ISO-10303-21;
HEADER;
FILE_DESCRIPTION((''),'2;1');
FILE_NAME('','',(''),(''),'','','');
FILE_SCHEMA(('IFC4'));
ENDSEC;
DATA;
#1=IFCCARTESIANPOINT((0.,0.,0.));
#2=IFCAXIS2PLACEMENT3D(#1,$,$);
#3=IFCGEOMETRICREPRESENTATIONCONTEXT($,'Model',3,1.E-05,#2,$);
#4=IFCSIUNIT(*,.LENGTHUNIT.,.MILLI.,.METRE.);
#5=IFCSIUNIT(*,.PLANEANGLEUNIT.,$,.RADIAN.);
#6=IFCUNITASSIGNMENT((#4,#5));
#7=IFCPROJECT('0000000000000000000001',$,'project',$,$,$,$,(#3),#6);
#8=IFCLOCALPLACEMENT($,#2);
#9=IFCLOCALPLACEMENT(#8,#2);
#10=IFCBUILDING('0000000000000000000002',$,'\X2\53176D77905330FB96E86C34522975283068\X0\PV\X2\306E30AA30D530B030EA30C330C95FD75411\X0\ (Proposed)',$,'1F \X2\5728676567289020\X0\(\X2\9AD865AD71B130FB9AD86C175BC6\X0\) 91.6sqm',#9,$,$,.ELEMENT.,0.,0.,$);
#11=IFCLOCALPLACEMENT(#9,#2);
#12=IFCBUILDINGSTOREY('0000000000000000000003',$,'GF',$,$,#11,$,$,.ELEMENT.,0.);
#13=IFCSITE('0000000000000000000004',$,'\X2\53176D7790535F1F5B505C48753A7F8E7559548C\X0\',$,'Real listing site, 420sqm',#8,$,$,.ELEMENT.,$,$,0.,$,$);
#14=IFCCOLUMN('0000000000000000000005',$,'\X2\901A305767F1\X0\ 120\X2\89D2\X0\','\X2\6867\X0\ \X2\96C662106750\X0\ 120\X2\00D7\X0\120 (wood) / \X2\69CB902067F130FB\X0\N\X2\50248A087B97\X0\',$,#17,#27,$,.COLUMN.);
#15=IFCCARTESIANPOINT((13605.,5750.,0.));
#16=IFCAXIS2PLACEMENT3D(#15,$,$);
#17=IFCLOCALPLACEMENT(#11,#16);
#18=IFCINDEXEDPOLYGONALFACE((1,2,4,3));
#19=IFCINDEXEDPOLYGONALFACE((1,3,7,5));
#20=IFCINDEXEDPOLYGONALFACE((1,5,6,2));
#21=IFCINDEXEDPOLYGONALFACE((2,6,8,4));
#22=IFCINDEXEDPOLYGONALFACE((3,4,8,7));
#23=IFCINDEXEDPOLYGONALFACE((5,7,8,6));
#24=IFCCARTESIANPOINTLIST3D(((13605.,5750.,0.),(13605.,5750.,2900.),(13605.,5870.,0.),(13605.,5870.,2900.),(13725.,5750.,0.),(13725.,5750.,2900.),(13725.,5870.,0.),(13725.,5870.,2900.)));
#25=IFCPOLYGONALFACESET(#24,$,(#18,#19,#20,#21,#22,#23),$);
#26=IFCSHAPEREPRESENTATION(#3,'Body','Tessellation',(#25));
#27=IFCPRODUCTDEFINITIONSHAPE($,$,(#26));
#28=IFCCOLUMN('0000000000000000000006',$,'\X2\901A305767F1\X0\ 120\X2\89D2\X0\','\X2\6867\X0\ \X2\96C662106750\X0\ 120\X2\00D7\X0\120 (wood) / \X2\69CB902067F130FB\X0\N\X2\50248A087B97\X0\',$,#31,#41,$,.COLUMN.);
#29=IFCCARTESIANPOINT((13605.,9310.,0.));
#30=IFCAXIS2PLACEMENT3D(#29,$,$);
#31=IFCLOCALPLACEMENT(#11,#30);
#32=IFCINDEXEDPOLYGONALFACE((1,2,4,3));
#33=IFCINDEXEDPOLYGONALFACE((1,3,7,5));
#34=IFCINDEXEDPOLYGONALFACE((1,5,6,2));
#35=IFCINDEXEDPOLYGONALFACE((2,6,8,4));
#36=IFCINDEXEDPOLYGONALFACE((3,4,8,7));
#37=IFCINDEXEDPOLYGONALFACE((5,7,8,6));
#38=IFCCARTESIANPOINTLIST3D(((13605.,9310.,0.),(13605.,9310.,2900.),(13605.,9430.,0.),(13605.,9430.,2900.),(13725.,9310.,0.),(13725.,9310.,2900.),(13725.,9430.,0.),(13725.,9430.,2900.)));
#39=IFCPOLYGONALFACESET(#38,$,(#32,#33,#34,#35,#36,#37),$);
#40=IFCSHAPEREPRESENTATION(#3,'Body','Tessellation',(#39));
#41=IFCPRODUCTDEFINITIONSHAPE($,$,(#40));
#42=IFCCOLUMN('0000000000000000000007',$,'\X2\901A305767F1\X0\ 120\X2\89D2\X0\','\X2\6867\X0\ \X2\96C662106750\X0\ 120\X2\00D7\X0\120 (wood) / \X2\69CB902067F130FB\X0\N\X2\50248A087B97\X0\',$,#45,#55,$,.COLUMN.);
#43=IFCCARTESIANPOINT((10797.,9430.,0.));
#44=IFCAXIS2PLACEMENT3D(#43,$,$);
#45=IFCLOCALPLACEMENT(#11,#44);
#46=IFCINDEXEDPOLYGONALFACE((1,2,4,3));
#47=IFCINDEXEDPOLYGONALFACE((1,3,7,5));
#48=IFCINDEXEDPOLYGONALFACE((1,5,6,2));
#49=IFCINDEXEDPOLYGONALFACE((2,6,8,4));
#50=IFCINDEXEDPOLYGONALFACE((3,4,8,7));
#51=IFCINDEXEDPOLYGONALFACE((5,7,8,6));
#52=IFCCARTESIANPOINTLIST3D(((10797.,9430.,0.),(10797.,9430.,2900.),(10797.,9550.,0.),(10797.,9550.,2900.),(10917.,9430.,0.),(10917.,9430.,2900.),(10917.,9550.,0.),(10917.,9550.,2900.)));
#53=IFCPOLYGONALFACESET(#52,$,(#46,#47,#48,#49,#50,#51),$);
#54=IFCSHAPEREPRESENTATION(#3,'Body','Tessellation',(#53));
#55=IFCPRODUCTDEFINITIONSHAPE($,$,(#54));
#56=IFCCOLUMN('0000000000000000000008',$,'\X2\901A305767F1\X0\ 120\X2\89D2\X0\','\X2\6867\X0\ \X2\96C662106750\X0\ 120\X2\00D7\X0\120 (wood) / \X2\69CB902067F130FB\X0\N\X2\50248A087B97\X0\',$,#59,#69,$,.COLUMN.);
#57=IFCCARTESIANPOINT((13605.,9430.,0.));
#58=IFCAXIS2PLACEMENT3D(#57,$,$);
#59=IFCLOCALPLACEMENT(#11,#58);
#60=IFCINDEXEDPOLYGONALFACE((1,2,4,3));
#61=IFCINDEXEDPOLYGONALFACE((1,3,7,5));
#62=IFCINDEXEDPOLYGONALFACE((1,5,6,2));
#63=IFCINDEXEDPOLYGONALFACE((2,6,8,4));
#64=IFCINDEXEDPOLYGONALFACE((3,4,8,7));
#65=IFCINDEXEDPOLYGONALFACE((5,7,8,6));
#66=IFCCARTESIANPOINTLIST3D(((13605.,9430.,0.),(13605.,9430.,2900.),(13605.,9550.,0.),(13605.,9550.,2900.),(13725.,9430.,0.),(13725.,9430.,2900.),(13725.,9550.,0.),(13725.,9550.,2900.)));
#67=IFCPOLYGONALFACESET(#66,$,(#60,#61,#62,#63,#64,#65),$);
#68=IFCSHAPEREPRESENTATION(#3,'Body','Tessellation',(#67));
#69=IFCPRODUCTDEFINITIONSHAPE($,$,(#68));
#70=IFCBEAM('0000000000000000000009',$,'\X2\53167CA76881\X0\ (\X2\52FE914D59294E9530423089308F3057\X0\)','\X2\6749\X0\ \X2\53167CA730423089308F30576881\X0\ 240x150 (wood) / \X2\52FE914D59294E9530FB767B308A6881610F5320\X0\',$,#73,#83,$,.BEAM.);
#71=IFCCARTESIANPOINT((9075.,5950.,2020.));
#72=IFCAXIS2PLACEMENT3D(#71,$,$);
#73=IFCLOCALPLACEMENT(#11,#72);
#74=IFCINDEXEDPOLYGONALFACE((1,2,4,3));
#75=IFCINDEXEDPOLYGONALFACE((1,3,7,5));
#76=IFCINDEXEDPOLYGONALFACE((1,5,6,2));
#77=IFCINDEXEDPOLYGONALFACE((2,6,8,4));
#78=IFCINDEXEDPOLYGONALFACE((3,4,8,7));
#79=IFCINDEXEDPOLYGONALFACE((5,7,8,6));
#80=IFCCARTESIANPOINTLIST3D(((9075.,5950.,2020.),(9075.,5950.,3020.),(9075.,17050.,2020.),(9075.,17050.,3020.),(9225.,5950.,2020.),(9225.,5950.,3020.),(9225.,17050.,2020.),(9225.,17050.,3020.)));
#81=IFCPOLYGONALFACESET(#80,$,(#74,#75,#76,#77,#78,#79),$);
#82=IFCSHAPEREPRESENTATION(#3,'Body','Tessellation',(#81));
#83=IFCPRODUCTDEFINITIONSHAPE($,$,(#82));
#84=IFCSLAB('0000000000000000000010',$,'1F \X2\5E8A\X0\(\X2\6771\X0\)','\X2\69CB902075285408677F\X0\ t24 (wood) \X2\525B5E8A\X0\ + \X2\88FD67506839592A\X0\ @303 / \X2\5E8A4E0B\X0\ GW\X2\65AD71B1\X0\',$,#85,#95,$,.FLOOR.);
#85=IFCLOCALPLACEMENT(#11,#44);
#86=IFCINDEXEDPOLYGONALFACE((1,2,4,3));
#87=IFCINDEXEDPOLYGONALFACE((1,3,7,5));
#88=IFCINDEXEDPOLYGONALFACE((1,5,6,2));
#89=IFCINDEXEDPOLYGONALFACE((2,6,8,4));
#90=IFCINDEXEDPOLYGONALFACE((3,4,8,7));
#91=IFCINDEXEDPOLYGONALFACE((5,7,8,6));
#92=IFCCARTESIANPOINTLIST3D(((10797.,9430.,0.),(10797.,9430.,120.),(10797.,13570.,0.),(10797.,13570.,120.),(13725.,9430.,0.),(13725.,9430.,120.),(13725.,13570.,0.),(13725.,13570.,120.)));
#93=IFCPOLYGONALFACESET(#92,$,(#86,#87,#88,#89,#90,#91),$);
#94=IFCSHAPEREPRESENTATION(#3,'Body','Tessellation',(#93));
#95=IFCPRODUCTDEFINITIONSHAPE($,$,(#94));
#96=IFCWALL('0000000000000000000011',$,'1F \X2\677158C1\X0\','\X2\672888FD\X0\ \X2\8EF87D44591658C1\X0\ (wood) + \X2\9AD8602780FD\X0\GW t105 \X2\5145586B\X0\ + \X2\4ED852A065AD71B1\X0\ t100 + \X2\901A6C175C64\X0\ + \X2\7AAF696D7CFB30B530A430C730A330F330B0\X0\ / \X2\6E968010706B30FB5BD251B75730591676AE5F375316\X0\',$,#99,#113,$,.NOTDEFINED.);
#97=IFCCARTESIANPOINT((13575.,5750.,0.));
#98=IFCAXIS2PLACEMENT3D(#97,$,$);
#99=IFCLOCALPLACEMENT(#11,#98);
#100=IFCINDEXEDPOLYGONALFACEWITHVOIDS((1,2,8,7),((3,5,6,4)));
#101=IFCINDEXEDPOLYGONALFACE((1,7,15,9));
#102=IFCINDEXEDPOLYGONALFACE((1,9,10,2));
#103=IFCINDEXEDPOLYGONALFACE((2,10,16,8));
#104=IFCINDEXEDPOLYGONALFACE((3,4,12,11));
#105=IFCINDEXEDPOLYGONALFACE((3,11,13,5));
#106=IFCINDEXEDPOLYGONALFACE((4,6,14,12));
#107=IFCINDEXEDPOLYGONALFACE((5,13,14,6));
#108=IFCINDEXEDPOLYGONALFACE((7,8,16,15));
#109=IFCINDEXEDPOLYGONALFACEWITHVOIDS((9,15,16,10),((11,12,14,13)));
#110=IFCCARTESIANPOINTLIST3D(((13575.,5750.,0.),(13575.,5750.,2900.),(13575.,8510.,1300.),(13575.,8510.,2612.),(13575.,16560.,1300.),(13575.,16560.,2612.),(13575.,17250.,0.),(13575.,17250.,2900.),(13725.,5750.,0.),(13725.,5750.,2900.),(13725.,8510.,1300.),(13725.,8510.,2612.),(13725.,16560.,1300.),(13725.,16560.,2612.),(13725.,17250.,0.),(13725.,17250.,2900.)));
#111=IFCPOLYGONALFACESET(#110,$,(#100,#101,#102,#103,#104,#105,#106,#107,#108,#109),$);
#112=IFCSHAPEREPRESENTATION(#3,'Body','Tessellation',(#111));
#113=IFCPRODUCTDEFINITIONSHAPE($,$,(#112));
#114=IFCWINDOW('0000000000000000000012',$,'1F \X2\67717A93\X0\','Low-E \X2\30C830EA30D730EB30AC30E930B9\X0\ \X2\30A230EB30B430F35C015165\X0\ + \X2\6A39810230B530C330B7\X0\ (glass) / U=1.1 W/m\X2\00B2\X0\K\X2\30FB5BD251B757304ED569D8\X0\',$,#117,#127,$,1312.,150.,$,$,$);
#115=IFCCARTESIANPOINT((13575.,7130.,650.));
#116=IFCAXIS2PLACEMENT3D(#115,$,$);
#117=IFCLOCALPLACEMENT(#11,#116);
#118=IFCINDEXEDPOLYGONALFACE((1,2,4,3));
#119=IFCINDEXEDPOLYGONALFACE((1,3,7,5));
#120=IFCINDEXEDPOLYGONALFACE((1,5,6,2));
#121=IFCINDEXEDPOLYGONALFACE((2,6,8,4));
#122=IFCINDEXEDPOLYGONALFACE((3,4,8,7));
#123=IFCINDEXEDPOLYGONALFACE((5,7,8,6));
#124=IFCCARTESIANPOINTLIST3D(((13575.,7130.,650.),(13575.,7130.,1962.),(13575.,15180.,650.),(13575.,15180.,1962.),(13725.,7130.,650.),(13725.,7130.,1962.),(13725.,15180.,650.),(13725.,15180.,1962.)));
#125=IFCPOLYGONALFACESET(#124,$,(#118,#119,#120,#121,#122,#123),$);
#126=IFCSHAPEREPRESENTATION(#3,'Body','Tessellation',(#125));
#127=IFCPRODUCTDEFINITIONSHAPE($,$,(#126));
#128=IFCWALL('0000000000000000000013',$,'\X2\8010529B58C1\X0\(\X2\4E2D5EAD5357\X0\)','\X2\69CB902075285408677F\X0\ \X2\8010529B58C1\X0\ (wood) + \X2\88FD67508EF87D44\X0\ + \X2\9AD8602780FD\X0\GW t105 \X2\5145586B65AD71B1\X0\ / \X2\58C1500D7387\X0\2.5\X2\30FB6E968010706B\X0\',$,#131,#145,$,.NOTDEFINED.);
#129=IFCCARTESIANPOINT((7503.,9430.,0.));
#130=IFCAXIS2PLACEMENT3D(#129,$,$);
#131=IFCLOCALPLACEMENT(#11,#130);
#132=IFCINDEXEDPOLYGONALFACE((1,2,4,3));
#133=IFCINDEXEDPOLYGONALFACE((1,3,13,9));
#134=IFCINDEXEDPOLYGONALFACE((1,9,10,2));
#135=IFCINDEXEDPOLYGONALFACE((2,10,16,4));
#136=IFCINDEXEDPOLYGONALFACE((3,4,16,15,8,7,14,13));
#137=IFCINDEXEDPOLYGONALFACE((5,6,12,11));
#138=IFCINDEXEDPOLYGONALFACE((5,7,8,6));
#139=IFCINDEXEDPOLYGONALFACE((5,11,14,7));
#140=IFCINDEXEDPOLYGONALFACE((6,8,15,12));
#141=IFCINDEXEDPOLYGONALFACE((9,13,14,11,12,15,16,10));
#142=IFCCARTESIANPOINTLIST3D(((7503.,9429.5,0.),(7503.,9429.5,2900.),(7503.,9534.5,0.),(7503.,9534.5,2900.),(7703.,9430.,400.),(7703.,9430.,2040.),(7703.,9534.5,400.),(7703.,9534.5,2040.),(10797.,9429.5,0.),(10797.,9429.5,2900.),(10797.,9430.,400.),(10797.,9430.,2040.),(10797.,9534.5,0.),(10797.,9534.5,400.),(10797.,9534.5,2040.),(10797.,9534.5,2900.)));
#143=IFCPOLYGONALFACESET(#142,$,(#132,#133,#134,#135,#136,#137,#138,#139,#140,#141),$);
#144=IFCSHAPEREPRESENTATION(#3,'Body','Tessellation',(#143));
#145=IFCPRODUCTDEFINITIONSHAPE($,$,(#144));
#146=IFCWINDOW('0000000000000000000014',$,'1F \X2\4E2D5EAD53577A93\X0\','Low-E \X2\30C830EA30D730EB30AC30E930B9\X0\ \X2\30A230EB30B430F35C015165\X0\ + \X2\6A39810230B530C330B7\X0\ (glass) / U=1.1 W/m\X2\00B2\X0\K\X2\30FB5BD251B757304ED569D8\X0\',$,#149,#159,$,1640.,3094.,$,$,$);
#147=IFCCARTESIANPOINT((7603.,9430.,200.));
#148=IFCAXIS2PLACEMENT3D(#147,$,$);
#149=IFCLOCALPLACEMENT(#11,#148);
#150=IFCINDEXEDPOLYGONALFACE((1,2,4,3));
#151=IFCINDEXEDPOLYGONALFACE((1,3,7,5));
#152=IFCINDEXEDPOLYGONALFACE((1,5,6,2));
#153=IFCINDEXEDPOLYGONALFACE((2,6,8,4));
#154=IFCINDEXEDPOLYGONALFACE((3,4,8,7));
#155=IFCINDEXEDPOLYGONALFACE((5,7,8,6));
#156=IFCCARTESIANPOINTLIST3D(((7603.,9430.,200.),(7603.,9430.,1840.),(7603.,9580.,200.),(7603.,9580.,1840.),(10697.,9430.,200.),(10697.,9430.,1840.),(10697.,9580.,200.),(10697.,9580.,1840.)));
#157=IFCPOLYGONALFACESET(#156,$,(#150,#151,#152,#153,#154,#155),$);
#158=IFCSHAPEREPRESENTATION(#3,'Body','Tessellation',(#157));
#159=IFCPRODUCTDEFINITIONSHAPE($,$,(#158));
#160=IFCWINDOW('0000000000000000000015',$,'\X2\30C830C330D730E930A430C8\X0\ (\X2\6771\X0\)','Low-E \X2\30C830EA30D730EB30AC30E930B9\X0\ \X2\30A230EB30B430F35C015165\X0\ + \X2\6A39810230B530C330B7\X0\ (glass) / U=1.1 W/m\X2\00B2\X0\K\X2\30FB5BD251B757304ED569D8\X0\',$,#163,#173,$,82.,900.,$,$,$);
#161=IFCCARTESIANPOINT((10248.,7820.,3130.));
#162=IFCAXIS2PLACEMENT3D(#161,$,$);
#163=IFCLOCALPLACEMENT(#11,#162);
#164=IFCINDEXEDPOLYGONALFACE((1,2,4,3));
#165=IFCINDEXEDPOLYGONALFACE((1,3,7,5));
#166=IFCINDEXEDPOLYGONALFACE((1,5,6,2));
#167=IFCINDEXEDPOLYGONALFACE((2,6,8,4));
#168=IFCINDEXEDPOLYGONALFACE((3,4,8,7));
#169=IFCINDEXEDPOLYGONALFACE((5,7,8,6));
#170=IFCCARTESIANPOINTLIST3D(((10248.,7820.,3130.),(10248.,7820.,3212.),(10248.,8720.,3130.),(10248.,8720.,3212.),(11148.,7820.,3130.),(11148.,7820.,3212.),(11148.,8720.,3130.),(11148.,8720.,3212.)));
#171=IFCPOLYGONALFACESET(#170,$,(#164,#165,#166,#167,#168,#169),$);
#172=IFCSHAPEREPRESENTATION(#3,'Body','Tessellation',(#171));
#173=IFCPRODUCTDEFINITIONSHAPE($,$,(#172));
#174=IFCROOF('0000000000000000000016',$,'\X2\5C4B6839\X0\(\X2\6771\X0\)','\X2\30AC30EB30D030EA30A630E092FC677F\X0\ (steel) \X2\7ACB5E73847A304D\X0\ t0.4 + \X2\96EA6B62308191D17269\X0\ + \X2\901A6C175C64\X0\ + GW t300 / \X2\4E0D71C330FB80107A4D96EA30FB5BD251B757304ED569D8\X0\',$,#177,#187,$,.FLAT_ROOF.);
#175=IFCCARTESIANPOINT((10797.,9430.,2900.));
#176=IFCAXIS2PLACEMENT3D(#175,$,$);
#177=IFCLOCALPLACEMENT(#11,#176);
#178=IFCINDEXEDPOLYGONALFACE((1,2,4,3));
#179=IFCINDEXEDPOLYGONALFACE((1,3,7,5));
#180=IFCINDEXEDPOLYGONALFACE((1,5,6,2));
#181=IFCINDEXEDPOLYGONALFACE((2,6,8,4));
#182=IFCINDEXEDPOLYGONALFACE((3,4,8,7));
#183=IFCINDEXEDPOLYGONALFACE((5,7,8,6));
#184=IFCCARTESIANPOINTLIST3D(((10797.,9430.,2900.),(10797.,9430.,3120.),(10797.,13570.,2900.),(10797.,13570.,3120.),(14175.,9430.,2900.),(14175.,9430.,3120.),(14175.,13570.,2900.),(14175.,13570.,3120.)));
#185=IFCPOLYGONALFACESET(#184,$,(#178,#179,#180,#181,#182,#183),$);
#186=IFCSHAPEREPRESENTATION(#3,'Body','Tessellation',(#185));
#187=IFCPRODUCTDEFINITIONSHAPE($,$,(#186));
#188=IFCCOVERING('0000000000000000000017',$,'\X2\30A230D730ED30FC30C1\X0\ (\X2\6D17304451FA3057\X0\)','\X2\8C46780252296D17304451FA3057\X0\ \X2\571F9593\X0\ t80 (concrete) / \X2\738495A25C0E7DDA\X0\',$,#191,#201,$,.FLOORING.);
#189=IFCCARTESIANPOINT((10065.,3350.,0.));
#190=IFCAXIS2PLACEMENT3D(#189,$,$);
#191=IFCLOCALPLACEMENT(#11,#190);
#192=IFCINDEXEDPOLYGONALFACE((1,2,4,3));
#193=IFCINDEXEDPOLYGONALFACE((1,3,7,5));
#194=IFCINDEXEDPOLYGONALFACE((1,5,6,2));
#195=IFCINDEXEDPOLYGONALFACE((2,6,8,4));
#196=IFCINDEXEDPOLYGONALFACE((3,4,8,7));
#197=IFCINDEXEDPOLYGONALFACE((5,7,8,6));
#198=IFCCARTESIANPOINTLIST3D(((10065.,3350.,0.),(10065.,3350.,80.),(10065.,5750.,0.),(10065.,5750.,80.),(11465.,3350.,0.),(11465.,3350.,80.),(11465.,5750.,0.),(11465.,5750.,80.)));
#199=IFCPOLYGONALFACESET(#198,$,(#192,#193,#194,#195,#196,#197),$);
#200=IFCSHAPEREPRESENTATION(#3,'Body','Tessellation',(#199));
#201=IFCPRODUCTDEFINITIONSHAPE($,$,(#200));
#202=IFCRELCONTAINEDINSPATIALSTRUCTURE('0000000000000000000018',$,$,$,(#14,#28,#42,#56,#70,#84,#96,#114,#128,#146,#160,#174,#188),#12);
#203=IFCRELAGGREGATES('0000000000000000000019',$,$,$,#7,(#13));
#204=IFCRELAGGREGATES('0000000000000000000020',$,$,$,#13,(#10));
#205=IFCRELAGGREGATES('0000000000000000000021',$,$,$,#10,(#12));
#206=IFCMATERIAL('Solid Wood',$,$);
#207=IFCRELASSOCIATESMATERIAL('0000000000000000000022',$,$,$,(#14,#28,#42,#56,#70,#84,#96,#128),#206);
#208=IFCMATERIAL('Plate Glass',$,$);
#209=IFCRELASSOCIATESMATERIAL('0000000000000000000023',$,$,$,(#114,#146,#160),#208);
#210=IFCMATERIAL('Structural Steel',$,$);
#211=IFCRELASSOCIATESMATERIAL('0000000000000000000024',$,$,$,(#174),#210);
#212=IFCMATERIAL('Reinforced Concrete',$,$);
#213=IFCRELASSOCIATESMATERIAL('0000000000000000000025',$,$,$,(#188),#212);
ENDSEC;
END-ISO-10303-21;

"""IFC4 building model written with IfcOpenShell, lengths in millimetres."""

from ifc_helpers import new_model, si_unit, frame, frame_2d, origin, place, context, project, spatial, rectangle, extrude, material, element, fill, save


model = new_model("IFC4")

# Units and contexts
model_context = context("Model", 3, precision=1e-05, world=origin())
ifc_project = project(units=[si_unit("LENGTHUNIT", "METRE", prefix="MILLI"), si_unit("PLANEANGLEUNIT", "RADIAN")], contexts=[model_context])

# Site, building, storey
site_placement = place(None, origin())
site = spatial("IfcSite", under=ifc_project, at=site_placement, Name="北海道弟子屈町美留和", ObjectType="Real listing site, 420sqm", CompositionType="ELEMENT", RefElevation=0.0)
building_placement = place(site_placement, origin())
building = spatial("IfcBuilding", under=site, at=building_placement, Name="北海道・雨水利用とPVのオフグリッド志向 (Proposed)", ObjectType="1F 在来木造(高断熱・高気密) 91.6sqm", CompositionType="ELEMENT", ElevationOfRefHeight=0.0, ElevationOfTerrain=0.0)
storey_placement = place(building_placement, origin())
storey = spatial("IfcBuildingStorey", under=building, at=storey_placement, Name="GF", CompositionType="ELEMENT", Elevation=0.0)

# Columns
ifc_material_1 = material(Name="Solid Wood")
column_1_placement = place(storey_placement, frame((13605.0, 5750.0, 0.0)))
element("IfcColumn", 1, at=column_1_placement, inside=storey, material=ifc_material_1, Name="通し柱 120角", Description="桧 集成材 120×120 (wood) / 構造柱・N値計算", PredefinedType="COLUMN", context=model_context, shape_type="SweptSolid", body=[
    extrude(rectangle(XDim=120.0, YDim=120.0, at=frame_2d((60.0, 60.0))), frame((13605.0, 5750.0, 0.0)), (0.0, 0.0, 1.0), 2900.0),
])
column_2_placement = place(storey_placement, frame((13605.0, 9310.0, 0.0)))
element("IfcColumn", 2, at=column_2_placement, inside=storey, material=ifc_material_1, Name="通し柱 120角", Description="桧 集成材 120×120 (wood) / 構造柱・N値計算", PredefinedType="COLUMN", context=model_context, shape_type="SweptSolid", body=[
    extrude(rectangle(XDim=120.0, YDim=120.0, at=frame_2d((60.0, 60.0))), frame((13605.0, 9310.0, 0.0)), (0.0, 0.0, 1.0), 2900.0),
])
column_3_placement = place(storey_placement, frame((10797.0, 9430.0, 0.0)))
element("IfcColumn", 3, at=column_3_placement, inside=storey, material=ifc_material_1, Name="通し柱 120角", Description="桧 集成材 120×120 (wood) / 構造柱・N値計算", PredefinedType="COLUMN", context=model_context, shape_type="SweptSolid", body=[
    extrude(rectangle(XDim=120.0, YDim=120.0, at=frame_2d((60.0, 60.0))), frame((10797.0, 9430.0, 0.0)), (0.0, 0.0, 1.0), 2900.0),
])
column_4_placement = place(storey_placement, frame((13605.0, 9430.0, 0.0)))
element("IfcColumn", 4, at=column_4_placement, inside=storey, material=ifc_material_1, Name="通し柱 120角", Description="桧 集成材 120×120 (wood) / 構造柱・N値計算", PredefinedType="COLUMN", context=model_context, shape_type="SweptSolid", body=[
    extrude(rectangle(XDim=120.0, YDim=120.0, at=frame_2d((60.0, 60.0))), frame((13605.0, 9430.0, 0.0)), (0.0, 0.0, 1.0), 2900.0),
])

# Beam
beam_1_placement = place(storey_placement, frame((9075.0, 5950.0, 2020.0)))
element("IfcBeam", 5, at=beam_1_placement, inside=storey, material=ifc_material_1, Name="化粧梁 (勾配天井あらわし)", Description="杉 化粧あらわし梁 240x150 (wood) / 勾配天井・登り梁意匠", PredefinedType="BEAM", context=model_context, shape_type="SweptSolid", body=[
    extrude(rectangle(XDim=150.0, YDim=11100.0, at=frame_2d((75.0, 5550.0))), frame((9075.0, 5950.0, 2020.0)), (0.0, 0.0, 1.0), 1000.0),
])

# Slab
slab_placement = place(storey_placement, frame((10797.0, 9430.0, 0.0)))
element("IfcSlab", 6, at=slab_placement, inside=storey, material=ifc_material_1, Name="1F 床(東)", Description="構造用合板 t24 (wood) 剛床 + 製材根太 @303 / 床下 GW断熱", PredefinedType="FLOOR", context=model_context, shape_type="SweptSolid", body=[
    extrude(rectangle(XDim=2928.0, YDim=4140.0, at=frame_2d((1464.0, 2070.0))), frame((10797.0, 9430.0, 0.0)), (0.0, 0.0, 1.0), 120.0),
])

# Walls, openings, windows
wall_1_placement = place(storey_placement, frame((13575.0, 5750.0, 0.0)))
wall_1 = element("IfcWall", 7, at=wall_1_placement, inside=storey, material=ifc_material_1, Name="1F 東壁", Description="木製 軸組外壁 (wood) + 高性能GW t105 充填 + 付加断熱 t100 + 通気層 + 窯業系サイディング / 準耐火・寒冷地外皮強化", PredefinedType="NOTDEFINED", context=model_context, shape_type="SweptSolid", body=[
    extrude(rectangle(XDim=150.0, YDim=11500.0, at=frame_2d((75.0, 5750.0))), frame((13575.0, 5750.0, 0.0)), (0.0, 0.0, 1.0), 2900.0),
])
opening_1_placement = place(storey_placement, frame((13575.0, 7130.0, 650.0)))
opening_1 = element("IfcOpeningElement", 8, at=opening_1_placement, cuts=wall_1, PredefinedType="NOTDEFINED", context=model_context, shape_type="SweptSolid", body=[
    extrude(rectangle(XDim=150.0, YDim=8050.0, at=frame_2d((75.0, 4025.0))), frame((13575.0, 7130.0, 650.0)), (0.0, 0.0, 1.0), 1312.0),
])
ifc_material_2 = material(Name="Plate Glass")
window_1_placement = place(storey_placement, frame((13575.0, 7130.0, 650.0)))
window_1 = element("IfcWindow", 9, at=window_1_placement, inside=storey, material=ifc_material_2, Name="1F 東窓", Description="Low-E トリプルガラス アルゴン封入 + 樹脂サッシ (glass) / U=1.1 W/m²K・寒冷地仕様", OverallHeight=1312.0, OverallWidth=150.0, context=model_context, shape_type="SweptSolid", body=[
    extrude(rectangle(XDim=150.0, YDim=8050.0, at=frame_2d((75.0, 4025.0))), frame((13575.0, 7130.0, 650.0)), (0.0, 0.0, 1.0), 1312.0),
])
fill(opening_1, window_1)
wall_2_placement = place(storey_placement, frame((7503.0, 9430.0, 0.0)))
wall_2 = element("IfcWall", 10, at=wall_2_placement, inside=storey, material=ifc_material_1, Name="耐力壁(中庭南)", Description="構造用合板 耐力壁 (wood) + 製材軸組 + 高性能GW t105 充填断熱 / 壁倍率2.5・準耐火", PredefinedType="NOTDEFINED", context=model_context, shape_type="SweptSolid", body=[
    extrude(rectangle(XDim=3294.0, YDim=105.0, at=frame_2d((1647.0, 52.0))), frame((7503.0, 9430.0, 0.0)), (0.0, 0.0, 1.0), 2900.0),
])
opening_2_placement = place(storey_placement, frame((7603.0, 9430.0, 200.0)))
opening_2 = element("IfcOpeningElement", 11, at=opening_2_placement, cuts=wall_2, PredefinedType="NOTDEFINED", context=model_context, shape_type="SweptSolid", body=[
    extrude(rectangle(XDim=3094.0, YDim=150.0, at=frame_2d((1547.0, 75.0))), frame((7603.0, 9430.0, 200.0)), (0.0, 0.0, 1.0), 1640.0),
])
window_2_placement = place(storey_placement, frame((7603.0, 9430.0, 200.0)))
window_2 = element("IfcWindow", 12, at=window_2_placement, inside=storey, material=ifc_material_2, Name="1F 中庭南窓", Description="Low-E トリプルガラス アルゴン封入 + 樹脂サッシ (glass) / U=1.1 W/m²K・寒冷地仕様", OverallHeight=1640.0, OverallWidth=3094.0, context=model_context, shape_type="SweptSolid", body=[
    extrude(rectangle(XDim=3094.0, YDim=150.0, at=frame_2d((1547.0, 75.0))), frame((7603.0, 9430.0, 200.0)), (0.0, 0.0, 1.0), 1640.0),
])
fill(opening_2, window_2)

# Window
window_3_placement = place(storey_placement, frame((10248.0, 7820.0, 3130.0)))
element("IfcWindow", 13, at=window_3_placement, inside=storey, material=ifc_material_2, Name="トップライト (東)", Description="Low-E トリプルガラス アルゴン封入 + 樹脂サッシ (glass) / U=1.1 W/m²K・寒冷地仕様", OverallHeight=82.0, OverallWidth=900.0, context=model_context, shape_type="SweptSolid", body=[
    extrude(rectangle(XDim=900.0, YDim=900.0, at=frame_2d((450.0, 450.0))), frame((10248.0, 7820.0, 3130.0)), (0.0, 0.0, 1.0), 82.0),
])

# Roof
ifc_material_3 = material(Name="Structural Steel")
roof_placement = place(storey_placement, frame((10797.0, 9430.0, 2900.0)))
element("IfcRoof", 14, at=roof_placement, inside=storey, material=ifc_material_3, Name="屋根(東)", Description="ガルバリウム鋼板 (steel) 立平葺き t0.4 + 雪止め金物 + 通気層 + GW t300 / 不燃・耐積雪・寒冷地仕様", PredefinedType="FLAT_ROOF", context=model_context, shape_type="SweptSolid", body=[
    extrude(rectangle(XDim=3378.0, YDim=4140.0, at=frame_2d((1689.0, 2070.0))), frame((10797.0, 9430.0, 2900.0)), (0.0, 0.0, 1.0), 220.0),
])

# Covering
ifc_material_4 = material(Name="Reinforced Concrete")
covering_placement = place(storey_placement, frame((10065.0, 3350.0, 0.0)))
element("IfcCovering", 15, at=covering_placement, inside=storey, material=ifc_material_4, Name="アプローチ (洗い出し)", Description="豆砂利洗い出し 土間 t80 (concrete) / 玄関導線", PredefinedType="FLOORING", context=model_context, shape_type="SweptSolid", body=[
    extrude(rectangle(XDim=1400.0, YDim=2400.0, at=frame_2d((700.0, 1200.0))), frame((10065.0, 3350.0, 0.0)), (0.0, 0.0, 1.0), 80.0),
])

save(model, "model.ifc")
